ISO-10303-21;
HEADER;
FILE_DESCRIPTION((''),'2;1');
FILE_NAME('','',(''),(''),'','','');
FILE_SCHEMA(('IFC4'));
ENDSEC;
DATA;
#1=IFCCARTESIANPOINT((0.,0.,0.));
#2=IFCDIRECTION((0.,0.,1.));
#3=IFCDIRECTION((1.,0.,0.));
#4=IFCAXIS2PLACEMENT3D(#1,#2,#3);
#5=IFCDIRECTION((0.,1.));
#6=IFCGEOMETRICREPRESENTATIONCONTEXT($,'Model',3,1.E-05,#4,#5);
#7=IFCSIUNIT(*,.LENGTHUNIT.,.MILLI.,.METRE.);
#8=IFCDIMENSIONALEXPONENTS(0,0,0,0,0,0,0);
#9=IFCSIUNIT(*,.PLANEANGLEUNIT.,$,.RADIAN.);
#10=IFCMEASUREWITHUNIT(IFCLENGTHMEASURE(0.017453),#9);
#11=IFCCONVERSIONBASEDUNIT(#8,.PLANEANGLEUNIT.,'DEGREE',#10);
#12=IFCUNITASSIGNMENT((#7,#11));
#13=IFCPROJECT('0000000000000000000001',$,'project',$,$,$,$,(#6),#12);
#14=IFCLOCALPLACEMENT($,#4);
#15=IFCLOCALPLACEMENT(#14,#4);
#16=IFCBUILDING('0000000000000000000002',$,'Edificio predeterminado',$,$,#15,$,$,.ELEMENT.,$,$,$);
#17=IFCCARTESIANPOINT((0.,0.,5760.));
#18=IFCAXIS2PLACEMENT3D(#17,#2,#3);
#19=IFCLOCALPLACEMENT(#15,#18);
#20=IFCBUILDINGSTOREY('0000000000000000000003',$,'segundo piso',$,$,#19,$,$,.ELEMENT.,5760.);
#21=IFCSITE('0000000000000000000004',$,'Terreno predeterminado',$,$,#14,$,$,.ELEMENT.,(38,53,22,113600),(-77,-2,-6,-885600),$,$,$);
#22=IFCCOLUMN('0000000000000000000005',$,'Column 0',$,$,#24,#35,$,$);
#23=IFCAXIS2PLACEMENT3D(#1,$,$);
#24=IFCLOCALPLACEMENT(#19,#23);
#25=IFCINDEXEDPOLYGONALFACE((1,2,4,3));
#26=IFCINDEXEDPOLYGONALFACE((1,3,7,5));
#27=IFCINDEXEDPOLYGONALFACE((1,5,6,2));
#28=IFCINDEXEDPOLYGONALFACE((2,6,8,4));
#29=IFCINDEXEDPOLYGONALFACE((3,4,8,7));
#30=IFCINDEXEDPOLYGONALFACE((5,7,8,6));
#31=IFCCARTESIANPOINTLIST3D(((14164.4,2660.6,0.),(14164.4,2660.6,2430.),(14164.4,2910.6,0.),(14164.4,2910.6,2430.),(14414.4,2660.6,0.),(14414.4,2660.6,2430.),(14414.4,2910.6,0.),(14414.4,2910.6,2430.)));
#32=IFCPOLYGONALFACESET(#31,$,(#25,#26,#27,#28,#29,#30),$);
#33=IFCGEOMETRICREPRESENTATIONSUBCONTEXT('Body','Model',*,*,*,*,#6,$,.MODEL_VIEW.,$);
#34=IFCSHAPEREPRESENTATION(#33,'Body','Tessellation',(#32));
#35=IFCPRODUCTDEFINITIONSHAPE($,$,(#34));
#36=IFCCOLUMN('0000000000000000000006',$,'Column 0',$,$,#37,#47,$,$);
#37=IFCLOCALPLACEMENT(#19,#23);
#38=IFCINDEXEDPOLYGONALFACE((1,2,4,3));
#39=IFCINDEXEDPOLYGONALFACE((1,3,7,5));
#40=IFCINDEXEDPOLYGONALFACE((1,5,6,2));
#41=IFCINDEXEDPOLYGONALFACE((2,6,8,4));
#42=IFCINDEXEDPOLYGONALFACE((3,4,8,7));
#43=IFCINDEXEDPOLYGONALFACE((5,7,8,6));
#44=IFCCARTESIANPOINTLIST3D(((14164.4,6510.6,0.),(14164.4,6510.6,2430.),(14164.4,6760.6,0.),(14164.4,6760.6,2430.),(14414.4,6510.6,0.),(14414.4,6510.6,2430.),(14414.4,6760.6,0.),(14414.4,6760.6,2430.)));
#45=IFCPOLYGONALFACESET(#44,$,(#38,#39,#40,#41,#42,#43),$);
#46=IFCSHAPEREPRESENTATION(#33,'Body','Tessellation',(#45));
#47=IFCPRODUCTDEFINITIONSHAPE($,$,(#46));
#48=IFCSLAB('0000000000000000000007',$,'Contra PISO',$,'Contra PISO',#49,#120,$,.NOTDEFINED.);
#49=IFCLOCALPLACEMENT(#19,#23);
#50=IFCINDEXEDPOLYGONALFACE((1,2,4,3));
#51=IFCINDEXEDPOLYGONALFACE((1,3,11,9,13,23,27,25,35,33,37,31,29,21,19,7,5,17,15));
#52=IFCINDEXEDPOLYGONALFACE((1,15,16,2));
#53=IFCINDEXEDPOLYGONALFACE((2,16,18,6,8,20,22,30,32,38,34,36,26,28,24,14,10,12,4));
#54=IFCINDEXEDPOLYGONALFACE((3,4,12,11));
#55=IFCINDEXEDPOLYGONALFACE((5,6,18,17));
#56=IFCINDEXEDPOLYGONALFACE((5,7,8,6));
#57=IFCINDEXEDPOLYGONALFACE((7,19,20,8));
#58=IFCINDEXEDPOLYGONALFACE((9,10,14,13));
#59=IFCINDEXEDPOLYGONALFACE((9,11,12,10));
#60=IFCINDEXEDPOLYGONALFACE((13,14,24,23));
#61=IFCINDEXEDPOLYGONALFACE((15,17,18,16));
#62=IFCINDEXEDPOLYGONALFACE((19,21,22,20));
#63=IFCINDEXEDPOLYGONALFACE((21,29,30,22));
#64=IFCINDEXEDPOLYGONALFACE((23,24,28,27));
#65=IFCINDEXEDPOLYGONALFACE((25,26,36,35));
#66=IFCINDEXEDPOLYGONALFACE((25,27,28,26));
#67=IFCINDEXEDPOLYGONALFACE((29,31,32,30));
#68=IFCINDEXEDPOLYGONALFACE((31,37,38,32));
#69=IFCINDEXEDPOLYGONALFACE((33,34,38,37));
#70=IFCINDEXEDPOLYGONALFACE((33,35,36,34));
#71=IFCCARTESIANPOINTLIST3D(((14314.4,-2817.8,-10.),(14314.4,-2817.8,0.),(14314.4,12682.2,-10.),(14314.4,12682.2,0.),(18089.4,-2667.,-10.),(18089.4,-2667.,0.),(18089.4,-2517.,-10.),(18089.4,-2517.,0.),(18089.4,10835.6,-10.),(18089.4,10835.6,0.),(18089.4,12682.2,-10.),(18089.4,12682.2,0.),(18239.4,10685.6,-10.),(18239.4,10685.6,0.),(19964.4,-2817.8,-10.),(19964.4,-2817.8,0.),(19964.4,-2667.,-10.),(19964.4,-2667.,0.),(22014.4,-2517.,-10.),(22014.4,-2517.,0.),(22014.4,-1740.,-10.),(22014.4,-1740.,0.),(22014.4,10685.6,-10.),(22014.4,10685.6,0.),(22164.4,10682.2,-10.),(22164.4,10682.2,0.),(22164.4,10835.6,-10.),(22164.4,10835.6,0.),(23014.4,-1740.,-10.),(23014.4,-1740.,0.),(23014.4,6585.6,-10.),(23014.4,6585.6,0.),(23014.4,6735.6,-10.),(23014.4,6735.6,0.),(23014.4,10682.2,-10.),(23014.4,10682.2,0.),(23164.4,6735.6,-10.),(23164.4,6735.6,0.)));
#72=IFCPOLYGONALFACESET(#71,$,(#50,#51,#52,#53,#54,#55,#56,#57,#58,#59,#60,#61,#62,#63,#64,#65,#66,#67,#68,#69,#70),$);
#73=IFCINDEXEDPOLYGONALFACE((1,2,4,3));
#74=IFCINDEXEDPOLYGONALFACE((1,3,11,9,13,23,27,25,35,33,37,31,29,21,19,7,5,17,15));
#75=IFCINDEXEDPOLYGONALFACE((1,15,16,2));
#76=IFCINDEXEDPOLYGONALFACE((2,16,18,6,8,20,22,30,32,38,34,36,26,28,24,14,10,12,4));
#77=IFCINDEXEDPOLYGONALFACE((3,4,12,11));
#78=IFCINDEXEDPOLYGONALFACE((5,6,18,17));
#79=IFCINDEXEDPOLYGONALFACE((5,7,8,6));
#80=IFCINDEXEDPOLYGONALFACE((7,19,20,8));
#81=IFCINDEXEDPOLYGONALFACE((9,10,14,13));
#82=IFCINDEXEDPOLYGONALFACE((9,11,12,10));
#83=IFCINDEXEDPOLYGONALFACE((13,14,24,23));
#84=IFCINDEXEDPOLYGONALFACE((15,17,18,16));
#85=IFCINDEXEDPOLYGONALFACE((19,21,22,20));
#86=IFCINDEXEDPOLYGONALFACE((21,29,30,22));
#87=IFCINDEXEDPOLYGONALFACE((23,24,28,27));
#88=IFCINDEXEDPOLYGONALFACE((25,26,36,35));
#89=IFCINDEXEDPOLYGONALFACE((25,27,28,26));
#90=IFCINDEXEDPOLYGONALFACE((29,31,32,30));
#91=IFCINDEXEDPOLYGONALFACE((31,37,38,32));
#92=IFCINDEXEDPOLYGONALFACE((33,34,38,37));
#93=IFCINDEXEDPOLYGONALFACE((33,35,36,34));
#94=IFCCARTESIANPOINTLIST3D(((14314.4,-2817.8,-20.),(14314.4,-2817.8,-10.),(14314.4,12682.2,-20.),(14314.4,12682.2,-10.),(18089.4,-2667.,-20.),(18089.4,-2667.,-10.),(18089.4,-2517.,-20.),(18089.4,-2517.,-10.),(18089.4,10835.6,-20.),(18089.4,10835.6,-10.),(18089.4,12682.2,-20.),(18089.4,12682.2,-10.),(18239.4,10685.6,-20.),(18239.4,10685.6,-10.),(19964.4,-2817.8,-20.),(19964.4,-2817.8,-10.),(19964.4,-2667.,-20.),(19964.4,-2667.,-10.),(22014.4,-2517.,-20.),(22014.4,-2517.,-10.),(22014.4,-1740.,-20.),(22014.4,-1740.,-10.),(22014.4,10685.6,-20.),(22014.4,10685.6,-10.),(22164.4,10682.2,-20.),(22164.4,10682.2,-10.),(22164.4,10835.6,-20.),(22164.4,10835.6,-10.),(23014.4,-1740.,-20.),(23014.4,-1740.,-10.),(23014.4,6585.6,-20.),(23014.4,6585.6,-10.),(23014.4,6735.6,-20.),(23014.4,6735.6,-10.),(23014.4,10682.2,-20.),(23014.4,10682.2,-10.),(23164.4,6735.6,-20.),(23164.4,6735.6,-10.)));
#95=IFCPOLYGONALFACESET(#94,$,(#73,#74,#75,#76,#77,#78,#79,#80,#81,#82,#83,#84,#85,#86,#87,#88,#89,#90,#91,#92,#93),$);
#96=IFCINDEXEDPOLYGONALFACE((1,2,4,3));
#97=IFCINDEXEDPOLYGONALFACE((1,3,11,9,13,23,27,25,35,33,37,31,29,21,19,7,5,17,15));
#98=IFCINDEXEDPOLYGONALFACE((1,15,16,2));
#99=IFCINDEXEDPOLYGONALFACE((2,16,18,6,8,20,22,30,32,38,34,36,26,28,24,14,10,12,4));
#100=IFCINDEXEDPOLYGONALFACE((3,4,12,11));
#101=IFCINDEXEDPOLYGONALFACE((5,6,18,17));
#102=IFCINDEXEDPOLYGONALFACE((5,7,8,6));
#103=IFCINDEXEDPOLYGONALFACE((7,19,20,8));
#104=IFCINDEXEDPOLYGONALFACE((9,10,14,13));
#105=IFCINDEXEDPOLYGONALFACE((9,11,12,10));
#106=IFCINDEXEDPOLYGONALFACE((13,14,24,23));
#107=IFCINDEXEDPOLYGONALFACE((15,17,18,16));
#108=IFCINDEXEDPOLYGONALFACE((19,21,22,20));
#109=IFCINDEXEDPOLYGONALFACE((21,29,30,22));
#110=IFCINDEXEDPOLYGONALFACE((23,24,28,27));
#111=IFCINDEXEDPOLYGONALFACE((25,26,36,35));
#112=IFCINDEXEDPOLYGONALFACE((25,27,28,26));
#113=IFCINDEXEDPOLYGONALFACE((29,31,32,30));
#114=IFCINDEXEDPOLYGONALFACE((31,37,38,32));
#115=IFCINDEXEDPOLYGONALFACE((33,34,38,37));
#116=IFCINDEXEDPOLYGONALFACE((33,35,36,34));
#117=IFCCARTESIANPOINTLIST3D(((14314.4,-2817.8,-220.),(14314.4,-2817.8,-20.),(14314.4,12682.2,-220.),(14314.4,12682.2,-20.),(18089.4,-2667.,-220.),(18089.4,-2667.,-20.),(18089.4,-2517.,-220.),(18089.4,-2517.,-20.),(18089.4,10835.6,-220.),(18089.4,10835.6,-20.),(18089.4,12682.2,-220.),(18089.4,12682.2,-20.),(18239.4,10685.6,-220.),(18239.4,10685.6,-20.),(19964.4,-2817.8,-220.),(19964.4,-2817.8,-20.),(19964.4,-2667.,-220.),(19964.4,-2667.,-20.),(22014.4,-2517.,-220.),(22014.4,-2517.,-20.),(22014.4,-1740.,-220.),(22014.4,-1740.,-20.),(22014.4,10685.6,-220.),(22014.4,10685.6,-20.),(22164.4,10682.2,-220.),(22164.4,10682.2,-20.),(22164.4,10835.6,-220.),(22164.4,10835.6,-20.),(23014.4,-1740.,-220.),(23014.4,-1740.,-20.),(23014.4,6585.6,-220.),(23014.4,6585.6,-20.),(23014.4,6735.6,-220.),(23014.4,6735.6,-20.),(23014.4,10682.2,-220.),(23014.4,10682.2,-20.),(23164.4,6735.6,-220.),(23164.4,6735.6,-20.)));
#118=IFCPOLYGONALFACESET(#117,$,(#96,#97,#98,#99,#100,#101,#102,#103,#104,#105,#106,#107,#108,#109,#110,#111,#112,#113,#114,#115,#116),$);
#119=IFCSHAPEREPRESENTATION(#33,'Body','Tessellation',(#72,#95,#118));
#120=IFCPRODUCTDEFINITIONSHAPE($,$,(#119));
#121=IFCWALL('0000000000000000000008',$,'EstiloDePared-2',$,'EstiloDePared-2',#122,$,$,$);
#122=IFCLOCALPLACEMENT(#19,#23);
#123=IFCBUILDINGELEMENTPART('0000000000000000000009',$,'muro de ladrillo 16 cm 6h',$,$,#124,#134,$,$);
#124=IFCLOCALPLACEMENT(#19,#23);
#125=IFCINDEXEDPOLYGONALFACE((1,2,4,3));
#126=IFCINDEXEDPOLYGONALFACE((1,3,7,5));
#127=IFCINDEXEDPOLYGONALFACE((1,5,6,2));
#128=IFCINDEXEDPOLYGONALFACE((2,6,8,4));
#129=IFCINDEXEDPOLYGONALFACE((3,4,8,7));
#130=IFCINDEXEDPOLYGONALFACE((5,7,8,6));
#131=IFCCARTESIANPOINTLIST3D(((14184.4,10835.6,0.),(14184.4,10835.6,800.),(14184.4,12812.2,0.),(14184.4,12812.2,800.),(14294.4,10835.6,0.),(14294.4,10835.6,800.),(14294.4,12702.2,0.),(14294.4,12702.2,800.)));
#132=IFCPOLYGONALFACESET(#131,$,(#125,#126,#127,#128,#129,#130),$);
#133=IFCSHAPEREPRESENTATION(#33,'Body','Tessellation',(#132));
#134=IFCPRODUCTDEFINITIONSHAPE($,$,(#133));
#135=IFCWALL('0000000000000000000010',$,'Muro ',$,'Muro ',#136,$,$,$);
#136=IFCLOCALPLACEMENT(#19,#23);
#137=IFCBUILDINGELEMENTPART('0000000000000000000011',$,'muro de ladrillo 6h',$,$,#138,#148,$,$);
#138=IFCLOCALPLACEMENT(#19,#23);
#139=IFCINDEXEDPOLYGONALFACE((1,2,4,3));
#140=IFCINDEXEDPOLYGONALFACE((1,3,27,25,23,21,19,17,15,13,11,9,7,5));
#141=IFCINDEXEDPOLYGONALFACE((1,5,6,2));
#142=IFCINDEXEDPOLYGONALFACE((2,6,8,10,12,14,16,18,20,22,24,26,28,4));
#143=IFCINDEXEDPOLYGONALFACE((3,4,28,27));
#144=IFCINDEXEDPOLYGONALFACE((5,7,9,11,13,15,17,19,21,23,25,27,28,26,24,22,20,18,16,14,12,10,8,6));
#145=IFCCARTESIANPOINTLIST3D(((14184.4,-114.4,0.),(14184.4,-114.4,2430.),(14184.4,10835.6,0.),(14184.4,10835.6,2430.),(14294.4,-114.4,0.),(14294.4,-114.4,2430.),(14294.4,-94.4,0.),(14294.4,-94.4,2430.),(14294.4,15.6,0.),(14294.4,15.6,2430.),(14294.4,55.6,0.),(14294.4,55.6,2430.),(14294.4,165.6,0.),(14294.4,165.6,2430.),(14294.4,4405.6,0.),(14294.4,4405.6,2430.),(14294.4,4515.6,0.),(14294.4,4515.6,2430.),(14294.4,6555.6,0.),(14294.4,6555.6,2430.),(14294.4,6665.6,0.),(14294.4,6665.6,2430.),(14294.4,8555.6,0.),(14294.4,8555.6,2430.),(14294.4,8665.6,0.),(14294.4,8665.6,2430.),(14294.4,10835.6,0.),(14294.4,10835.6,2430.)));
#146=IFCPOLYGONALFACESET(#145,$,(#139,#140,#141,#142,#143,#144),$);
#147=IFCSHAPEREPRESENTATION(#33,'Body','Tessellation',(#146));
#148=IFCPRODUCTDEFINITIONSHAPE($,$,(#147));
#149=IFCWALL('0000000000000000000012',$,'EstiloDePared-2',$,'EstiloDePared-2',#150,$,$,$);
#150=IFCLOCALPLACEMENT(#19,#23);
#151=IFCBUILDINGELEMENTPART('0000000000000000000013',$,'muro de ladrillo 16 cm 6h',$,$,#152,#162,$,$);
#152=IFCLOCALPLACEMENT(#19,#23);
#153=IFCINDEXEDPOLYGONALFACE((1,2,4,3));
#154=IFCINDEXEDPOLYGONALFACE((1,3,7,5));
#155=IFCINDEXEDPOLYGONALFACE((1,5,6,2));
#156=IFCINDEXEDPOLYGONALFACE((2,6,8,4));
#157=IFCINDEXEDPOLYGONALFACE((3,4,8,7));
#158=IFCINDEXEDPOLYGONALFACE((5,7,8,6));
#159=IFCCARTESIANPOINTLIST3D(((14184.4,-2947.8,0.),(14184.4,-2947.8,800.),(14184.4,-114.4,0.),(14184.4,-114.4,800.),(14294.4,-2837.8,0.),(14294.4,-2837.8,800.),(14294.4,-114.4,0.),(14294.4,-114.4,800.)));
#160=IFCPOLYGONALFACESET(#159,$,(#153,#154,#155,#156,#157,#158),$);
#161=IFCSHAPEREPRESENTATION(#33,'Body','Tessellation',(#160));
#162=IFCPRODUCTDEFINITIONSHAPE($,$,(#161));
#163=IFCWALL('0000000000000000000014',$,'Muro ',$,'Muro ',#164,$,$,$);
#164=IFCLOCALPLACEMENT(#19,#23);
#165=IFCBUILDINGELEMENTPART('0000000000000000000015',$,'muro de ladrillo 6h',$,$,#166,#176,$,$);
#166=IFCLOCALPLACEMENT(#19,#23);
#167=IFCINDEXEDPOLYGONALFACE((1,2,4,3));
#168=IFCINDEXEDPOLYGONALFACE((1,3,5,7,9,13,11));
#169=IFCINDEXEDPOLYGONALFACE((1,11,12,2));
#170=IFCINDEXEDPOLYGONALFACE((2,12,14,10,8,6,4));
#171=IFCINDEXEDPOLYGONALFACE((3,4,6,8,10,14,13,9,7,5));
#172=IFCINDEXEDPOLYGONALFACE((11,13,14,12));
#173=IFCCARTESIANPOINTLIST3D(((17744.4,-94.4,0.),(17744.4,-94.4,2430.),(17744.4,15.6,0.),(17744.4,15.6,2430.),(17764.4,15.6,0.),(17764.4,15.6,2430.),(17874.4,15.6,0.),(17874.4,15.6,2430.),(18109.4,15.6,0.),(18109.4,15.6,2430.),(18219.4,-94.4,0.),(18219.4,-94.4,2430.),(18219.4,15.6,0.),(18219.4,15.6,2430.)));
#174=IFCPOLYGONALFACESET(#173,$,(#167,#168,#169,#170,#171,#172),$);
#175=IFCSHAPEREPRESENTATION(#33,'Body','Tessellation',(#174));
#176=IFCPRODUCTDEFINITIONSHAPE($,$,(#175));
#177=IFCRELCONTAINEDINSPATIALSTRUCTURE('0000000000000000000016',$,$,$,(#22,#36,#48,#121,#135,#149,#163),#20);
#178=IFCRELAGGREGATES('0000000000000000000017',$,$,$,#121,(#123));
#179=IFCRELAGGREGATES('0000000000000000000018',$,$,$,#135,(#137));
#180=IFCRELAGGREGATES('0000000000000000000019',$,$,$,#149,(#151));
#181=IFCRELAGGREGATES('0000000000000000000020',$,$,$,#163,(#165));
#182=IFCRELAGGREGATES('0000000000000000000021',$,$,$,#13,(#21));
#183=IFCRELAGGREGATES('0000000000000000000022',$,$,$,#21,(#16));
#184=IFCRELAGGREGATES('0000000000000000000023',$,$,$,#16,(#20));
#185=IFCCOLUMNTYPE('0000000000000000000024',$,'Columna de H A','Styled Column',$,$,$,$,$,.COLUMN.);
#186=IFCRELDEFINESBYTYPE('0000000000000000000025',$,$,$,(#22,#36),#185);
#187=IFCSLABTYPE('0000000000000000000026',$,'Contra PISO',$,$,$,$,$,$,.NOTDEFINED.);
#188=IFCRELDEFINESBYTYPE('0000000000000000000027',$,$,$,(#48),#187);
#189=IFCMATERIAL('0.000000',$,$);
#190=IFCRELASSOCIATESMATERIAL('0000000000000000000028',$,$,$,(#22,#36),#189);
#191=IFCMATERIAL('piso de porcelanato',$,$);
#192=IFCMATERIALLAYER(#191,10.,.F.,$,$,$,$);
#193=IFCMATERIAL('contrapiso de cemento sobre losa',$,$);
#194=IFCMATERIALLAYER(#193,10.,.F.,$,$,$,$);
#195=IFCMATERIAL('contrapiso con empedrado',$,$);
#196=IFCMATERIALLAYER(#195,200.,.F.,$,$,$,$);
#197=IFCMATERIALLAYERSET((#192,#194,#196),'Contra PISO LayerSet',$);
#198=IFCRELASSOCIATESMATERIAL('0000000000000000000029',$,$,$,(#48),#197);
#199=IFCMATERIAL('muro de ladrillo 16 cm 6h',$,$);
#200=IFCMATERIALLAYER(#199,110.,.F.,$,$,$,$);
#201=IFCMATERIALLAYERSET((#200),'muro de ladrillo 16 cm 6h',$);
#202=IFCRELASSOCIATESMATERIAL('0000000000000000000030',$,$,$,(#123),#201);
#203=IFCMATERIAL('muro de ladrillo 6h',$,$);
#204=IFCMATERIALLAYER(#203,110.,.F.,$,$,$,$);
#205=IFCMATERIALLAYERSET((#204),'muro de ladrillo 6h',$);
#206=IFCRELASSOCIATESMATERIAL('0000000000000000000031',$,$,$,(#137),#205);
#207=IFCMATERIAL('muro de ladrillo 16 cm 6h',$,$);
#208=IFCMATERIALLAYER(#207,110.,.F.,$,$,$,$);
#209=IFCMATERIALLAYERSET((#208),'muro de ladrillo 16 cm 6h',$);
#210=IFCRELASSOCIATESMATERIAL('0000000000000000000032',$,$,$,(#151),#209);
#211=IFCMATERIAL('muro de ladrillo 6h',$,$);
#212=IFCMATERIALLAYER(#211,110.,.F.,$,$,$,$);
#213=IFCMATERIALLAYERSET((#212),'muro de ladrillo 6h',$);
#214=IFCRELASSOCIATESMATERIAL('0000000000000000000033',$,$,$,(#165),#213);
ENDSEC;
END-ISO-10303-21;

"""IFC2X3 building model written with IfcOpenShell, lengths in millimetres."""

from ifc_helpers import new_model, entity, si_unit, converted_unit, direction, frame, origin_with_axes, place, context, subcontext, project, spatial, polyline, outline, extrude, material, layer, layer_set, layer_usage, type_object, element, aggregate, save


model = new_model("IFC2X3")

# Units and contexts
model_context = context("Model", 3, precision=1e-05, world=origin_with_axes(), true_north=direction((0.0, 1.0)))
body_context = subcontext(model_context, "Body", "Model", "MODEL_VIEW")
ifc_project = project(units=[si_unit("LENGTHUNIT", "METRE", prefix="MILLI"), converted_unit("PLANEANGLEUNIT", "DEGREE", entity("IfcLengthMeasure", 0.017453), si_unit("PLANEANGLEUNIT", "RADIAN"), dimensions=[0, 0, 0, 0, 0, 0, 0])], contexts=[model_context])

# Site, building, storey
site_placement = place(None, origin_with_axes())
site = spatial("IfcSite", under=ifc_project, at=site_placement, Name="Terreno predeterminado", CompositionType="ELEMENT", RefLatitude=(38, 53, 22, 113600), RefLongitude=(-77, -2, -6, -885600))
building_placement = place(site_placement, origin_with_axes())
building = spatial("IfcBuilding", under=site, at=building_placement, Name="Edificio predeterminado", CompositionType="ELEMENT")
storey_placement = place(building_placement, frame((0.0, 0.0, 5760.0), z_axis=(0.0, 0.0, 1.0), x_axis=(1.0, 0.0, 0.0)))
storey = spatial("IfcBuildingStorey", under=building, at=storey_placement, Name="segundo piso", CompositionType="ELEMENT", Elevation=5760.0)

# Columns
ifc_material_1 = material(Name="0.000000")
column_type = type_object("IfcColumnType", Name="Columna de H A", Description="Styled Column", PredefinedType="COLUMN")
for number, where, z_axis, x_axis, name in (
    (1, (14289.4, 2785.6, 0.0), (0.0, 0.0, 1.0), (1.0, 0.0, 0.0), "Column 0"),
    (2, (14289.4, 6635.6, 0.0), (0.0, 0.0, 1.0), (1.0, 0.0, 0.0), "Column 0"),
):
    element("IfcColumn", number, at=place(storey_placement, frame(where, z_axis=z_axis, x_axis=x_axis)), inside=storey, type_object=column_type, material=ifc_material_1, Name=name, context=body_context, shape_type="SweptSolid", body=[
        extrude(outline(polyline([(-125.0, -125.0), (125.0, -125.0), (125.0, 125.0), (-125.0, 125.0), (-125.0, -125.0)])), origin_with_axes(), (0.0, 0.0, 1.0), 2430.0),
    ])

# Slab
ifc_material_2 = material(Name="piso de porcelanato")
ifc_layer_1 = layer(ifc_material_2, 10.0, ventilated=False)
ifc_material_3 = material(Name="contrapiso de cemento sobre losa")
ifc_layer_2 = layer(ifc_material_3, 10.0, ventilated=False)
ifc_material_4 = material(Name="contrapiso con empedrado")
ifc_layer_3 = layer(ifc_material_4, 200.0, ventilated=False)
ifc_layer_set_1 = layer_set([ifc_layer_1, ifc_layer_2, ifc_layer_3], Name="Contra PISO LayerSet")
ifc_layer_usage_1 = layer_usage(ifc_layer_set_1, "AXIS3", "POSITIVE", 0.0)
slab_type = type_object("IfcSlabType", Name="Contra PISO", PredefinedType="NOTDEFINED")
slab_placement = place(storey_placement, frame((0.0, 0.0, -5760.0), z_axis=(0.0, 0.0, 1.0), x_axis=(1.0, 0.0, 0.0)))
element("IfcSlab", 3, at=slab_placement, inside=storey, type_object=slab_type, material=ifc_layer_usage_1, Name="Contra PISO", ObjectType="Contra PISO", PredefinedType="NOTDEFINED", context=body_context, shape_type="SweptSolid", body=[
    extrude(outline(polyline([(0.0, -777.0), (-1000.0, -777.0), (-1000.0, -9102.6), (-1150.0, -9252.6), (-1000.0, -9252.6), (-1000.0, -13199.1), (-150.0, -13199.1), (-150.0, -13352.6), (0.0, -13202.6), (3775.0, -13202.6), (3925.0, -13352.6), (3925.0, -15199.1), (7700.0, -15199.1), (7700.0, 300.9), (2050.0, 300.9), (2050.0, 150.0), (3925.0, 150.0), (3925.0, 0.0), (0.0, 0.0), (0.0, -777.0)])), frame((22014.4, -2517.0, 5750.0), z_axis=(0.0, 0.0, 1.0), x_axis=(-1.0, 0.0, 0.0)), (0.0, 0.0, 1.0), 10.0),
    extrude(outline(polyline([(0.0, -777.0), (-1000.0, -777.0), (-1000.0, -9102.6), (-1150.0, -9252.6), (-1000.0, -9252.6), (-1000.0, -13199.1), (-150.0, -13199.1), (-150.0, -13352.6), (0.0, -13202.6), (3775.0, -13202.6), (3925.0, -13352.6), (3925.0, -15199.1), (7700.0, -15199.1), (7700.0, 300.9), (2050.0, 300.9), (2050.0, 150.0), (3925.0, 150.0), (3925.0, 0.0), (0.0, 0.0), (0.0, -777.0)])), frame((22014.4, -2517.0, 5740.0), z_axis=(0.0, 0.0, 1.0), x_axis=(-1.0, 0.0, 0.0)), (0.0, 0.0, 1.0), 10.0),
    extrude(outline(polyline([(0.0, -777.0), (-1000.0, -777.0), (-1000.0, -9102.6), (-1150.0, -9252.6), (-1000.0, -9252.6), (-1000.0, -13199.1), (-150.0, -13199.1), (-150.0, -13352.6), (0.0, -13202.6), (3775.0, -13202.6), (3925.0, -13352.6), (3925.0, -15199.1), (7700.0, -15199.1), (7700.0, 300.9), (2050.0, 300.9), (2050.0, 150.0), (3925.0, 150.0), (3925.0, 0.0), (0.0, 0.0), (0.0, -777.0)])), frame((22014.4, -2517.0, 5540.0), z_axis=(0.0, 0.0, 1.0), x_axis=(-1.0, 0.0, 0.0)), (0.0, 0.0, 1.0), 200.0),
])

# Walls, building element parts
wall_1_placement = place(storey_placement, frame((14239.4, 12757.2, 0.0), z_axis=(0.0, 0.0, 1.0), x_axis=(0.0, -1.0, 0.0)))
wall_1 = element("IfcWall", 4, at=wall_1_placement, inside=storey, Name="EstiloDePared-2", ObjectType="EstiloDePared-2")
ifc_material_5 = material(Name="muro de ladrillo 16 cm 6h")
ifc_layer_4 = layer(ifc_material_5, 110.0, ventilated=False)
ifc_layer_set_2 = layer_set([ifc_layer_4], Name="muro de ladrillo 16 cm 6h")
ifc_layer_usage_2 = layer_usage(ifc_layer_set_2, "AXIS2", "NEGATIVE", -55.0)
building_element_part_1_placement = place(wall_1_placement, origin_with_axes())
building_element_part_1 = element("IfcBuildingElementPart", 5, at=building_element_part_1_placement, material=ifc_layer_usage_2, Name="muro de ladrillo 16 cm 6h", context=body_context, shape_type="SweptSolid", body=[
    extrude(outline(polyline([(1921.6, 55.0), (1921.6, -55.0), (-55.0, -55.0), (55.0, 55.0), (1921.6, 55.0)])), origin_with_axes(), (0.0, 0.0, 1.0), 800.0),
])
aggregate(wall_1, [building_element_part_1])
wall_2_placement = place(storey_placement, frame((14239.4, 10835.6, 0.0), z_axis=(0.0, 0.0, 1.0), x_axis=(0.0, -1.0, 0.0)))
wall_2 = element("IfcWall", 6, at=wall_2_placement, inside=storey, Name="Muro ", ObjectType="Muro ")
ifc_material_6 = material(Name="muro de ladrillo 6h")
ifc_layer_5 = layer(ifc_material_6, 110.0, ventilated=False)
ifc_layer_set_3 = layer_set([ifc_layer_5], Name="muro de ladrillo 6h")
ifc_layer_usage_3 = layer_usage(ifc_layer_set_3, "AXIS2", "NEGATIVE", -55.0)
building_element_part_2_placement = place(wall_2_placement, origin_with_axes())
building_element_part_2 = element("IfcBuildingElementPart", 7, at=building_element_part_2_placement, material=ifc_layer_usage_3, Name="muro de ladrillo 6h", context=body_context, shape_type="SweptSolid", body=[
    extrude(outline(polyline([(4280.0, 55.0), (6320.0, 55.0), (6430.0, 55.0), (10670.0, 55.0), (10780.0, 55.0), (10820.0, 55.0), (10930.0, 55.0), (10950.0, 55.0), (10950.0, -55.0), (0.0, -55.0), (0.0, 55.0), (2170.0, 55.0), (2280.0, 55.0), (4170.0, 55.0), (4280.0, 55.0)])), origin_with_axes(), (0.0, 0.0, 1.0), 2430.0),
])
aggregate(wall_2, [building_element_part_2])
wall_3_placement = place(storey_placement, frame((14239.4, -2892.8, 0.0), z_axis=(0.0, 0.0, 1.0), x_axis=(0.0, 1.0, 0.0)))
wall_3 = element("IfcWall", 8, at=wall_3_placement, inside=storey, Name="EstiloDePared-2", ObjectType="EstiloDePared-2")
ifc_material_7 = material(Name="muro de ladrillo 16 cm 6h")
ifc_layer_6 = layer(ifc_material_7, 110.0, ventilated=False)
ifc_layer_set_4 = layer_set([ifc_layer_6], Name="muro de ladrillo 16 cm 6h")
ifc_layer_usage_4 = layer_usage(ifc_layer_set_4, "AXIS2", "NEGATIVE", -55.0)
building_element_part_3_placement = place(wall_3_placement, origin_with_axes())
building_element_part_3 = element("IfcBuildingElementPart", 9, at=building_element_part_3_placement, material=ifc_layer_usage_4, Name="muro de ladrillo 16 cm 6h", context=body_context, shape_type="SweptSolid", body=[
    extrude(outline(polyline([(2778.4, 55.0), (2778.4, -55.0), (55.0, -55.0), (-55.0, 55.0), (2778.4, 55.0)])), origin_with_axes(), (0.0, 0.0, 1.0), 800.0),
])
aggregate(wall_3, [building_element_part_3])
wall_4_placement = place(storey_placement, frame((18164.4, -39.4, 0.0), z_axis=(0.0, 0.0, 1.0), x_axis=(-1.0, 0.0, 0.0)))
wall_4 = element("IfcWall", 10, at=wall_4_placement, inside=storey, Name="Muro ", ObjectType="Muro ")
ifc_material_8 = material(Name="muro de ladrillo 6h")
ifc_layer_7 = layer(ifc_material_8, 110.0, ventilated=False)
ifc_layer_set_5 = layer_set([ifc_layer_7], Name="muro de ladrillo 6h")
ifc_layer_usage_5 = layer_usage(ifc_layer_set_5, "AXIS2", "NEGATIVE", -55.0)
building_element_part_4_placement = place(wall_4_placement, origin_with_axes())
building_element_part_4 = element("IfcBuildingElementPart", 11, at=building_element_part_4_placement, material=ifc_layer_usage_5, Name="muro de ladrillo 6h", context=body_context, shape_type="SweptSolid", body=[
    extrude(outline(polyline([(420.0, 55.0), (420.0, -55.0), (400.0, -55.0), (290.0, -55.0), (55.0, -55.0), (-55.0, -55.0), (-55.0, 55.0), (420.0, 55.0)])), origin_with_axes(), (0.0, 0.0, 1.0), 2430.0),
])
aggregate(wall_4, [building_element_part_4])

save(model, "model.ifc")
